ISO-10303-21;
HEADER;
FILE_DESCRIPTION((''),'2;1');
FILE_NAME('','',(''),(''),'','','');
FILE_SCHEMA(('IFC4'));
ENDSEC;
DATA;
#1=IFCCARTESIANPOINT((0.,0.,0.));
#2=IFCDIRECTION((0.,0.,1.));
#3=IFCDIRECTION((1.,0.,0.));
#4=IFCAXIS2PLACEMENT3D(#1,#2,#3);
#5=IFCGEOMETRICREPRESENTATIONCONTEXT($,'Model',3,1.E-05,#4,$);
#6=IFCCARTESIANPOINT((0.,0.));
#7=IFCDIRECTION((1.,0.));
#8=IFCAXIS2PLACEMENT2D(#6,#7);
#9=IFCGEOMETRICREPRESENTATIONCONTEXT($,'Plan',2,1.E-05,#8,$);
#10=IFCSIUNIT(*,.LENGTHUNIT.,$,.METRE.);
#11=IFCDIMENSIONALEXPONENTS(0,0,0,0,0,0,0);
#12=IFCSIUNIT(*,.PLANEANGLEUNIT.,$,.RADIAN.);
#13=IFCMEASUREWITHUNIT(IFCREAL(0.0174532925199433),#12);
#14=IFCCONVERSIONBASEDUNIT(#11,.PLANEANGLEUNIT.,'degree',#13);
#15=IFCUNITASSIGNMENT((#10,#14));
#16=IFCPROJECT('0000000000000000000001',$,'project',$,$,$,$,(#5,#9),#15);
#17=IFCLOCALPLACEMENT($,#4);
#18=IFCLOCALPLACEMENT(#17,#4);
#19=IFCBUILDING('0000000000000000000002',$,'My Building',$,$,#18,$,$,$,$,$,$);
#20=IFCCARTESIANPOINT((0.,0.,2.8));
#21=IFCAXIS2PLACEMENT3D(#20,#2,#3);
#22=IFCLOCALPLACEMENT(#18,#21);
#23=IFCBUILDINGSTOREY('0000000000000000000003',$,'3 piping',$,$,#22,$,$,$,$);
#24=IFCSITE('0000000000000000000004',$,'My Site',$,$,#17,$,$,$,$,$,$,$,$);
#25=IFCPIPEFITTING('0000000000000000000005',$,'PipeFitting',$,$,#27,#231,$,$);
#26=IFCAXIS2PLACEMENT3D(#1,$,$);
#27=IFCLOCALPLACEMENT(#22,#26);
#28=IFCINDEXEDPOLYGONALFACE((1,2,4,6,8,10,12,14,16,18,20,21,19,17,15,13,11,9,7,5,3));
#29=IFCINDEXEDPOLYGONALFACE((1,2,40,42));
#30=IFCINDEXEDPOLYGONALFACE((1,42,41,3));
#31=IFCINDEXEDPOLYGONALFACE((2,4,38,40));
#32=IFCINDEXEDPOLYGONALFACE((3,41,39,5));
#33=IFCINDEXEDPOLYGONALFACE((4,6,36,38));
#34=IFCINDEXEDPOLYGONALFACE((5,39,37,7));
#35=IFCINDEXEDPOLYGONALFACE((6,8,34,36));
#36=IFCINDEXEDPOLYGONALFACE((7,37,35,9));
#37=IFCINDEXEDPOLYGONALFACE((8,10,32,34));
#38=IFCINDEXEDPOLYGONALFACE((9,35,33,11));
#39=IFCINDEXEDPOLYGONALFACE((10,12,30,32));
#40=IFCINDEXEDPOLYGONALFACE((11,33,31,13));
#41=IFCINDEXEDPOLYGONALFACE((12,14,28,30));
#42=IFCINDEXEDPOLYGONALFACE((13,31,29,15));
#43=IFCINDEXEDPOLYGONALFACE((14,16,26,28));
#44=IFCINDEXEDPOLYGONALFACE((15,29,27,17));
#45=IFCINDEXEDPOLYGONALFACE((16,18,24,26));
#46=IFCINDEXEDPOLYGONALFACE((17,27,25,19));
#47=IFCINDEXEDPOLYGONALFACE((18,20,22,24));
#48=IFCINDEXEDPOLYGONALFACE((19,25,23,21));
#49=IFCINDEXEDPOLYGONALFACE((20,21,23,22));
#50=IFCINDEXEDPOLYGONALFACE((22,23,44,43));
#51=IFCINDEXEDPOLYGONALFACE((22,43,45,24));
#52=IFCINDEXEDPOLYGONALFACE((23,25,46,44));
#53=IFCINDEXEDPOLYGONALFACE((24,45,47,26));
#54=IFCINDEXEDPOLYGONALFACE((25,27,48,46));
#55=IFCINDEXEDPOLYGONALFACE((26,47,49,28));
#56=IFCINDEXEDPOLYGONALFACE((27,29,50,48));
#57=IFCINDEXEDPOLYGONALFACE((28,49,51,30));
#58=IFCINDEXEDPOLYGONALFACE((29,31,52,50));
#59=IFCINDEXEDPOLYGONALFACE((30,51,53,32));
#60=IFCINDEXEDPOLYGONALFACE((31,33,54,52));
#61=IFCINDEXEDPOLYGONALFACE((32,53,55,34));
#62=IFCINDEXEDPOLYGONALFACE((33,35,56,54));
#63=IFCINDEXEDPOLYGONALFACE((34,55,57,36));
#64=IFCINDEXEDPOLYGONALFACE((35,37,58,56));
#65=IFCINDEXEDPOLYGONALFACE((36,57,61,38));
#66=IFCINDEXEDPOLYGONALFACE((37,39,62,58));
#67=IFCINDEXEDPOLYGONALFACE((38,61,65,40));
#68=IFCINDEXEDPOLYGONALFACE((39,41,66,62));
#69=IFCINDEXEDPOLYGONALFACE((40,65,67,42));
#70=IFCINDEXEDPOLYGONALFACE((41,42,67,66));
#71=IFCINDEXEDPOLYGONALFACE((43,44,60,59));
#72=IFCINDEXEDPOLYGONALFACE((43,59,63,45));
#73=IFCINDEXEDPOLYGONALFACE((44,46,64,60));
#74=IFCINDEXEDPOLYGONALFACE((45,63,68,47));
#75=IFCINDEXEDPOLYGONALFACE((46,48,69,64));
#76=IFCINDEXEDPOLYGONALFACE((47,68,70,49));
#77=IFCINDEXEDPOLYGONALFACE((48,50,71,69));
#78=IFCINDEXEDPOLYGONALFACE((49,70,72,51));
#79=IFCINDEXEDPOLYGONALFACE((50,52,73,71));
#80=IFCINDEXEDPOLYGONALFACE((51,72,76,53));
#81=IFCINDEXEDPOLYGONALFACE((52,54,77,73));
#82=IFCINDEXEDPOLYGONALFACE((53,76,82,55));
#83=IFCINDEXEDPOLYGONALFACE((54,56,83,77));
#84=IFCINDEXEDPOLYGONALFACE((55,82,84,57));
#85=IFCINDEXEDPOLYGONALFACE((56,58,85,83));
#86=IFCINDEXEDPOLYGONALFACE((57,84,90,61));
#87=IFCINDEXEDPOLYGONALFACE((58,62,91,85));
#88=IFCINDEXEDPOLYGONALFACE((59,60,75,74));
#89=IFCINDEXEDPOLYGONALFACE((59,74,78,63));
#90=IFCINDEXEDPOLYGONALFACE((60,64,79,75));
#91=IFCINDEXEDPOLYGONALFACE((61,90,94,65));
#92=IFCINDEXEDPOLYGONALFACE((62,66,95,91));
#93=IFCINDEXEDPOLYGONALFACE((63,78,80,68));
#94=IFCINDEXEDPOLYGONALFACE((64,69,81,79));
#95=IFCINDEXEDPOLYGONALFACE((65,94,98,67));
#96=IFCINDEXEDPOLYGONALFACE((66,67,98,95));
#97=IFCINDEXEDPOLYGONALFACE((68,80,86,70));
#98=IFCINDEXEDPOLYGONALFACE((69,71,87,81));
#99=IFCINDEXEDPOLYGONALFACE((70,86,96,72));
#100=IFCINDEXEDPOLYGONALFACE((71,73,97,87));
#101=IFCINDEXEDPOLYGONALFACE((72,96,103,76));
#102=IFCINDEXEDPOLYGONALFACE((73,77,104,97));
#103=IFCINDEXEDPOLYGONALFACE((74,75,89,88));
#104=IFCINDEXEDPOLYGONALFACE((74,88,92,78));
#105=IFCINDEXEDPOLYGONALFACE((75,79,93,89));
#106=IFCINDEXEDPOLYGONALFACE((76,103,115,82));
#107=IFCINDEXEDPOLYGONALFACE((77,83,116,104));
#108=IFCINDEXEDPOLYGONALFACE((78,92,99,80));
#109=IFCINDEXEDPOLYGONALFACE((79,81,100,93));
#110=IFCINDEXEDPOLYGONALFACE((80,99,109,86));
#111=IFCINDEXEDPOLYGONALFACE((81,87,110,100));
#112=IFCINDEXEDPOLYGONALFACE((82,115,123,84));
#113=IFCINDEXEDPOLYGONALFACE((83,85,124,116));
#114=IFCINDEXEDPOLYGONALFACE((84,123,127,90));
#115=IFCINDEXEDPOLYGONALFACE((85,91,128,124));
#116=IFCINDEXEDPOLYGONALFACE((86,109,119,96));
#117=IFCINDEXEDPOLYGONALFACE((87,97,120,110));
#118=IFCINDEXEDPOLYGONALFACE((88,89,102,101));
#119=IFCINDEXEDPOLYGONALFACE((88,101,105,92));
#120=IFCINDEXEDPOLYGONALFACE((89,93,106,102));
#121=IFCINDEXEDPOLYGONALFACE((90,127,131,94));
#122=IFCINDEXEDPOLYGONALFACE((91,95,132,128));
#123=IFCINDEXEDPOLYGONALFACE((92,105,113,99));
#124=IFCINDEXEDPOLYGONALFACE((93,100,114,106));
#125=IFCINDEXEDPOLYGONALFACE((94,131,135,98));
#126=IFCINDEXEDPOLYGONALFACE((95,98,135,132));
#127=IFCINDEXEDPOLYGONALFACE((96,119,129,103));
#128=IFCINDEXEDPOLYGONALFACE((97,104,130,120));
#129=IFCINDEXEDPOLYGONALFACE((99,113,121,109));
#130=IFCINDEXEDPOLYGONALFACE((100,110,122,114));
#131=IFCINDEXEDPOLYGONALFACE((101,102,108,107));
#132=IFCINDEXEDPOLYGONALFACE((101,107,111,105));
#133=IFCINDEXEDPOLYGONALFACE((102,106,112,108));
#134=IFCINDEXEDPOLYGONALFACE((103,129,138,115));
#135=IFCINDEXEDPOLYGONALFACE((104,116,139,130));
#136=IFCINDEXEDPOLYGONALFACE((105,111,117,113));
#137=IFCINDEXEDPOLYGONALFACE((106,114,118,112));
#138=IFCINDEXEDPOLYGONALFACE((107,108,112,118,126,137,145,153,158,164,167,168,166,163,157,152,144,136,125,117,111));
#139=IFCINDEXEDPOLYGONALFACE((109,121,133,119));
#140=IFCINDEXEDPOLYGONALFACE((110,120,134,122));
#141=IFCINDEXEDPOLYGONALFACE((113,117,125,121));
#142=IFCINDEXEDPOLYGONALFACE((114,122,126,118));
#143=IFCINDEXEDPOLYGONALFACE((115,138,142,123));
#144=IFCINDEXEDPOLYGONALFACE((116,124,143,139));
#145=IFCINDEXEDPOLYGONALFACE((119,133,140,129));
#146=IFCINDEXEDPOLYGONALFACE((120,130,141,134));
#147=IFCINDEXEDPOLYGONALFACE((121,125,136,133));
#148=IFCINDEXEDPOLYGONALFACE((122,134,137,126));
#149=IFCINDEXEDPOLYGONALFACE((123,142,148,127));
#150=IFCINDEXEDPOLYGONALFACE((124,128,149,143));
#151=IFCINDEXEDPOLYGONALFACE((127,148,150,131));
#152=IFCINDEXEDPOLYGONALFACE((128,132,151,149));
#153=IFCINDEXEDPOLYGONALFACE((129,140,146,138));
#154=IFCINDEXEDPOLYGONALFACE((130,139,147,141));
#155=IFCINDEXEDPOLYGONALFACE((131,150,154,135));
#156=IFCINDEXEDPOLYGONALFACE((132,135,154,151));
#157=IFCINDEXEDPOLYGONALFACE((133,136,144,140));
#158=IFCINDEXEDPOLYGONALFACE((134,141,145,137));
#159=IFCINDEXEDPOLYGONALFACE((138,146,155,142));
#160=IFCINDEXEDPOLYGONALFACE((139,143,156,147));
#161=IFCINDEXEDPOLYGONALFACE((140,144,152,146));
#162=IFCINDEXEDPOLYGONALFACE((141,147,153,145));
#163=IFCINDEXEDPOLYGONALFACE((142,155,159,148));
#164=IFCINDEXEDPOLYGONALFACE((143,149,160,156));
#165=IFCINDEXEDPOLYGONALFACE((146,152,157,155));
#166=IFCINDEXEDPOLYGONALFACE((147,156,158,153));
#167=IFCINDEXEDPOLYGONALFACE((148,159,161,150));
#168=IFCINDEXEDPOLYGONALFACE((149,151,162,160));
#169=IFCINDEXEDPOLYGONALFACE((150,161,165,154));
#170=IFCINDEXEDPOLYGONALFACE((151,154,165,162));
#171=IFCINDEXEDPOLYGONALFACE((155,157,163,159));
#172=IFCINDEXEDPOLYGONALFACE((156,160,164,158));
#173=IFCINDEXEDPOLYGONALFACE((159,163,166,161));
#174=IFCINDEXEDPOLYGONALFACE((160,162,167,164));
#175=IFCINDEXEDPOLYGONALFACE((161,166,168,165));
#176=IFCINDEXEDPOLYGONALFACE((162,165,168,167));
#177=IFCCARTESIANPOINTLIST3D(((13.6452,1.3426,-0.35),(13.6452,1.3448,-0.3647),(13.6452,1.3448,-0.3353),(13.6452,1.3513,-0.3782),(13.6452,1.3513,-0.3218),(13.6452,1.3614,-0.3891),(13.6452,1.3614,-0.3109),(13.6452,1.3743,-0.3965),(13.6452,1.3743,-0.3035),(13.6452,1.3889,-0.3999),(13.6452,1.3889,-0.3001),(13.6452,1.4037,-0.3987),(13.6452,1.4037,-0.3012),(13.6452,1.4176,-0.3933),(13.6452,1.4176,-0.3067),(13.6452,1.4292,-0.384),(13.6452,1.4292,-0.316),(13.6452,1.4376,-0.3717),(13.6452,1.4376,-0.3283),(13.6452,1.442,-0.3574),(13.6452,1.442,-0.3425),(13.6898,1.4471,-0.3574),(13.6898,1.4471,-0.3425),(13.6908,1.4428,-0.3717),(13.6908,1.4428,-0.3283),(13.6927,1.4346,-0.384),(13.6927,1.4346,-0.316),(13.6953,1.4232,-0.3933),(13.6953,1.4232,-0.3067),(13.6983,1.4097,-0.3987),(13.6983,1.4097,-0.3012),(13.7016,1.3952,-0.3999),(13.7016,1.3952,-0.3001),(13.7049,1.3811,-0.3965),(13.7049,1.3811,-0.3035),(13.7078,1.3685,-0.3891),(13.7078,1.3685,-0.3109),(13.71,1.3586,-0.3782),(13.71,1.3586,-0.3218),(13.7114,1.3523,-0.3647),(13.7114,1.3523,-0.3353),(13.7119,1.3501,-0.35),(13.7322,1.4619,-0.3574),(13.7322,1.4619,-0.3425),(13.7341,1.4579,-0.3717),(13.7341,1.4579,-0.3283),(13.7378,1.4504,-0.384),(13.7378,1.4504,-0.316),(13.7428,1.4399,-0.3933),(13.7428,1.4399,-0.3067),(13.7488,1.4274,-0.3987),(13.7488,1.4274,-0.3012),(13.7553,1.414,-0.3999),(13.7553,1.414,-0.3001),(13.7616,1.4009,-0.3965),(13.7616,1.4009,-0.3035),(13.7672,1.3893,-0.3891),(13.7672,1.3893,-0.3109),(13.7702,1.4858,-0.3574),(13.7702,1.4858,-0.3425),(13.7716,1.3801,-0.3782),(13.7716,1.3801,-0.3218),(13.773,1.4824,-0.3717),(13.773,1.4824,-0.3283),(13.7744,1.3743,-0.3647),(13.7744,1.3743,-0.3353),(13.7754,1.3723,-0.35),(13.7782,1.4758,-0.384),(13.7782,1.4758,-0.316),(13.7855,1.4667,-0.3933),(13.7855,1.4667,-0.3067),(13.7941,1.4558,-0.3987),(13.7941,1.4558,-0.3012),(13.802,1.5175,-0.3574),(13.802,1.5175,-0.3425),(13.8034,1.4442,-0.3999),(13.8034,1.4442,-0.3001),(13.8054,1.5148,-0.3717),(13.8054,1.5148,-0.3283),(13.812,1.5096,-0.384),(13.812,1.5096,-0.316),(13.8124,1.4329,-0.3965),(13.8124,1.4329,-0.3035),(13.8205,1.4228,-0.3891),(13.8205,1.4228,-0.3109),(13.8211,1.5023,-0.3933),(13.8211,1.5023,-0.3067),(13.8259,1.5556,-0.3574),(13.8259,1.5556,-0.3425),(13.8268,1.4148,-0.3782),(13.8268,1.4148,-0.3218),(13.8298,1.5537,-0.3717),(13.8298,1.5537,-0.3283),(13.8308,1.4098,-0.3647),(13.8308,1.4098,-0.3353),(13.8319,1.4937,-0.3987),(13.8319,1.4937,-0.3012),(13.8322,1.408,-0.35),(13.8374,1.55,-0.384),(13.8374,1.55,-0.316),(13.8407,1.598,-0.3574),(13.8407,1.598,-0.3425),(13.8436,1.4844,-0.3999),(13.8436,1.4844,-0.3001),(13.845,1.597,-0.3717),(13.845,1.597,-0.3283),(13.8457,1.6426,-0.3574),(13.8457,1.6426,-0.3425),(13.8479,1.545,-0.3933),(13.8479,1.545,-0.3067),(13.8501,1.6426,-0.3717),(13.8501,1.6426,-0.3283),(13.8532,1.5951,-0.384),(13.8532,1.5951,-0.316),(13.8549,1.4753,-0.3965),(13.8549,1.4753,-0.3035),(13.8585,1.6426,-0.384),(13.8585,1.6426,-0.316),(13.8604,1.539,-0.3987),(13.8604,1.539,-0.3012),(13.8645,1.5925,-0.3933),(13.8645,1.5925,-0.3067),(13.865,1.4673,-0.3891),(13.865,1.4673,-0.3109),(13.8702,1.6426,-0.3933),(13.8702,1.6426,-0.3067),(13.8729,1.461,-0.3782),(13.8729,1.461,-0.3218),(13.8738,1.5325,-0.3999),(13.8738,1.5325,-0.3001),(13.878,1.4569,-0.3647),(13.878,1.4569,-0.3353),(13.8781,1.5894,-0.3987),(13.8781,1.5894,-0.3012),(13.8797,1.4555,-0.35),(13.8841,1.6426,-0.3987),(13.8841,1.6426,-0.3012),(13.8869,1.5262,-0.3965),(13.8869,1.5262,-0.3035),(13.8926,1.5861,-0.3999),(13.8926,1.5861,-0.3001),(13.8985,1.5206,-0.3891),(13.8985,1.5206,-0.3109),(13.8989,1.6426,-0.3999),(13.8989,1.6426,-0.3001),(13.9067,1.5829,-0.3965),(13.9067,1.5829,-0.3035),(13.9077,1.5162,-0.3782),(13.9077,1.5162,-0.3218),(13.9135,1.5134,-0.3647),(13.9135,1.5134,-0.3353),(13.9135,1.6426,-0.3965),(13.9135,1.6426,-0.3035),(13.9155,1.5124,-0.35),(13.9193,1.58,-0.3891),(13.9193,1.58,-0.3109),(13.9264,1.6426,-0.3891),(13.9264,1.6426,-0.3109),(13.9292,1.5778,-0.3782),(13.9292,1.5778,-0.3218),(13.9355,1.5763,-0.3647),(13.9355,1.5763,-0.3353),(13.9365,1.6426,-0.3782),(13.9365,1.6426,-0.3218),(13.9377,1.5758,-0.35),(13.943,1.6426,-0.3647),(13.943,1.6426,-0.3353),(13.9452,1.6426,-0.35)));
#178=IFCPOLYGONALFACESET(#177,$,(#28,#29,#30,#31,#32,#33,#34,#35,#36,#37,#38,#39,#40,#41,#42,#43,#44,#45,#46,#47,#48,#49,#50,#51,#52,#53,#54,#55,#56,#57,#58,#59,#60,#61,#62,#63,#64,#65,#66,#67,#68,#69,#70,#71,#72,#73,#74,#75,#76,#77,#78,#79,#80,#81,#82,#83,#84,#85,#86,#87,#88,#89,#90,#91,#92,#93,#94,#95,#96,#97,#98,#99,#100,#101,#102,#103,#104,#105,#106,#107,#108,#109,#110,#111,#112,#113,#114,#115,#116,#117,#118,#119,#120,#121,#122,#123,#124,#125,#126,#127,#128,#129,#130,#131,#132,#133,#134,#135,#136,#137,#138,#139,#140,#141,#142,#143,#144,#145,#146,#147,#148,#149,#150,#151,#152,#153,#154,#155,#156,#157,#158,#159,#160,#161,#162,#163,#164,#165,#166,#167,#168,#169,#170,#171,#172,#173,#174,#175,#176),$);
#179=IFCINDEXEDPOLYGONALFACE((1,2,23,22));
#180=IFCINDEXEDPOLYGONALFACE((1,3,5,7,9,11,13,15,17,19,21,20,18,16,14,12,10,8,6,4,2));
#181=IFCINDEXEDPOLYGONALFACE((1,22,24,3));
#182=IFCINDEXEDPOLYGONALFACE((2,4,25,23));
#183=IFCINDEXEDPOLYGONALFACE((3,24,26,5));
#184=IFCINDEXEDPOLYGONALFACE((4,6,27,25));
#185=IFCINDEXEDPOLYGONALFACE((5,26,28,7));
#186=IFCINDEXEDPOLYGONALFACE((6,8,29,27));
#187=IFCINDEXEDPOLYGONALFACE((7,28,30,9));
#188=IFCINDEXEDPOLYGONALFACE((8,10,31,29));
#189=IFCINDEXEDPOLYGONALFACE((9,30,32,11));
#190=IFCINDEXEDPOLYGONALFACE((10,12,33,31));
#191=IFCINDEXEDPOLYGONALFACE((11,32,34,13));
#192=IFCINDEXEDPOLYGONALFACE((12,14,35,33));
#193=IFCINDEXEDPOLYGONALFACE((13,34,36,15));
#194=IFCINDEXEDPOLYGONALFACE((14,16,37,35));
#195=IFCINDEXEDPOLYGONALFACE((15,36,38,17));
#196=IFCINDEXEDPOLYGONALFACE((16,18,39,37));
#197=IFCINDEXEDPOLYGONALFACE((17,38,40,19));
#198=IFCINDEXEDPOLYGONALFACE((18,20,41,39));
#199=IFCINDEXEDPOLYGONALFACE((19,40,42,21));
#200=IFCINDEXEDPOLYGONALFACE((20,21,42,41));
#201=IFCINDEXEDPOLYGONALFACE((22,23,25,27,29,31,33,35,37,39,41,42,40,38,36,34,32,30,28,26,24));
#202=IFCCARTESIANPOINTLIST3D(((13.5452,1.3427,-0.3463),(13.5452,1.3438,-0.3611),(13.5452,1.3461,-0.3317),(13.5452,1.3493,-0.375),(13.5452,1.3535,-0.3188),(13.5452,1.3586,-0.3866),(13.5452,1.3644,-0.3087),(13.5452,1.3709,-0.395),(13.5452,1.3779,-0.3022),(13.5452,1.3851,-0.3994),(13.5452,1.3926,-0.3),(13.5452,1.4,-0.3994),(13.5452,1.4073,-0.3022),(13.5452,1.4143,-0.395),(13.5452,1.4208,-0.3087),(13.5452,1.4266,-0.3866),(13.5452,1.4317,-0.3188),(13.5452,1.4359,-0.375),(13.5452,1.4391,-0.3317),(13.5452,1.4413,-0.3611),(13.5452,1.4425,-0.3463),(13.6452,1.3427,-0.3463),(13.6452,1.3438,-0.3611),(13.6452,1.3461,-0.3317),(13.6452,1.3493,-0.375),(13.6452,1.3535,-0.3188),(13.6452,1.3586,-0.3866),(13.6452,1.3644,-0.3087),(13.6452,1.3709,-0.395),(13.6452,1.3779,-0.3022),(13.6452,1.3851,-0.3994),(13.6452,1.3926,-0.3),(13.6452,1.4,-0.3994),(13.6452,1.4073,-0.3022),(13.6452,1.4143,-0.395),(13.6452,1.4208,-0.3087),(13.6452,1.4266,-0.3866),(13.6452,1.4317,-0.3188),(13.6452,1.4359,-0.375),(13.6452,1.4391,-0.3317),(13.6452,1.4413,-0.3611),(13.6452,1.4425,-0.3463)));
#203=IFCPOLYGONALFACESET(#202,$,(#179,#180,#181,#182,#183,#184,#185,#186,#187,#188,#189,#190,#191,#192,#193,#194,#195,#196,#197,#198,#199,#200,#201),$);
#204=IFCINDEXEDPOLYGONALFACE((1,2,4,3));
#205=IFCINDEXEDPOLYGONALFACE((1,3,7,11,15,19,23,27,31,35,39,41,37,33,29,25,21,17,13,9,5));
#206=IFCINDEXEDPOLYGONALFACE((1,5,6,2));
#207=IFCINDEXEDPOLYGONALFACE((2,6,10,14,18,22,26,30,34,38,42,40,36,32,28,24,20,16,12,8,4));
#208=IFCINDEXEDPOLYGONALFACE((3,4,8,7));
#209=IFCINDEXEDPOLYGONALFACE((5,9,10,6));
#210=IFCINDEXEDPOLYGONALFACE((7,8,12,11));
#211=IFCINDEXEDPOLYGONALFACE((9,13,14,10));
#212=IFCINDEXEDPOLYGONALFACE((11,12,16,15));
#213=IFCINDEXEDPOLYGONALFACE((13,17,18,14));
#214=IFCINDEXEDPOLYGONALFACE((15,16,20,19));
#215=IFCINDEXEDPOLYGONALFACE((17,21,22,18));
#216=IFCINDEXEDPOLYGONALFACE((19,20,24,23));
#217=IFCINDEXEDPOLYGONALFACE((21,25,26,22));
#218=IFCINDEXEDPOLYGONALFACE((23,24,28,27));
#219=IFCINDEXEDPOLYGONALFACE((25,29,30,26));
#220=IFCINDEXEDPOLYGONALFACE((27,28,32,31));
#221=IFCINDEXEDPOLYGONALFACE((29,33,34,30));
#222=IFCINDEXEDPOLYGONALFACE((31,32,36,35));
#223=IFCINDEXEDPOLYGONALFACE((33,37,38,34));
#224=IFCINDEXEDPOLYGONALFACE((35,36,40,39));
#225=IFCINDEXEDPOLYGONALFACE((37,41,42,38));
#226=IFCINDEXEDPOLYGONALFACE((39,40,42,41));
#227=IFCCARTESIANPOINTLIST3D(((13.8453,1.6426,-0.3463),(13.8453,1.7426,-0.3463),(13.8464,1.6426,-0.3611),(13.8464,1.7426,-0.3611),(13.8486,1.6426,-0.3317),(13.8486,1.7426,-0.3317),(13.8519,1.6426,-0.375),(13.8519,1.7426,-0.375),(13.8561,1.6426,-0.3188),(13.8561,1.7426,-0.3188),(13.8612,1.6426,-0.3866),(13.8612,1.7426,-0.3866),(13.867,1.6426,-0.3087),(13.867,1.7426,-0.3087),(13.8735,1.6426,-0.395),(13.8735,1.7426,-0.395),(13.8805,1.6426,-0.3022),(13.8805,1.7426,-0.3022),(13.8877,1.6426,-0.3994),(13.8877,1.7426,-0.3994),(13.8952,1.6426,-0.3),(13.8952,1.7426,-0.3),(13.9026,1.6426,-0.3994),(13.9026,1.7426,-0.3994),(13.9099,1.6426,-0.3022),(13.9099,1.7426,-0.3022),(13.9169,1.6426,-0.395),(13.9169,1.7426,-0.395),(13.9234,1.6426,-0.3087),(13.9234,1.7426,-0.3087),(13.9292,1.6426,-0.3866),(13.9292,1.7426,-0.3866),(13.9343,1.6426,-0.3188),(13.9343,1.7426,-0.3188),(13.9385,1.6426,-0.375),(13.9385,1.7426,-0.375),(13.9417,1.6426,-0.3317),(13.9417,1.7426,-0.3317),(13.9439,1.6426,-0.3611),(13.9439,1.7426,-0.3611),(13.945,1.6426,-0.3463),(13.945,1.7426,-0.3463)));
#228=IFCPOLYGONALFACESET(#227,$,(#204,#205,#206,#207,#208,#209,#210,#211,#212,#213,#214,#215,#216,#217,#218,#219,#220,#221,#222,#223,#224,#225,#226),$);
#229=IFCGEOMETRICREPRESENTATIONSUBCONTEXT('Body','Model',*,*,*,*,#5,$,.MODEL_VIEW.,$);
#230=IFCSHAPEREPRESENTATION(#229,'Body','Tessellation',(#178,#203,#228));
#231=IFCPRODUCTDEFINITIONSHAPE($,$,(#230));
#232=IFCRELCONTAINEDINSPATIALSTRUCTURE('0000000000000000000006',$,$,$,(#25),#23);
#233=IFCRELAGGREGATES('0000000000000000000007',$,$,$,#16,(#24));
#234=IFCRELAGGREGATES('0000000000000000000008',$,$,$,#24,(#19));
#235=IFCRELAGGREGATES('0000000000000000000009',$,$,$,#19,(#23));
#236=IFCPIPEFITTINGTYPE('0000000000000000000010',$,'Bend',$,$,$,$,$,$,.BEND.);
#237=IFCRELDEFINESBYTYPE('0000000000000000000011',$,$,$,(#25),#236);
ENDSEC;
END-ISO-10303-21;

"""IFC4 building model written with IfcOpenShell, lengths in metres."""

from ifc_helpers import new_model, entity, si_unit, converted_unit, frame, origin_with_axes, origin_2d_with_axis, place, context, subcontext, project, spatial, circle, extrude, source, transform, mapped, type_object, type_shapes, element, save


model = new_model("IFC4")

# Units and contexts
model_context = context("Model", 3, precision=1e-05, world=origin_with_axes())
plan_context = context("Plan", 2, precision=1e-05, world=origin_2d_with_axis())
body_context = subcontext(model_context, "Body", "Model", "MODEL_VIEW")
ifc_project = project(units=[si_unit("LENGTHUNIT", "METRE"), converted_unit("PLANEANGLEUNIT", "degree", entity("IfcReal", 0.0174532925199433), si_unit("PLANEANGLEUNIT", "RADIAN"), dimensions=[0, 0, 0, 0, 0, 0, 0])], contexts=[model_context, plan_context])

# Site, building, storey
site_placement = place(None, origin_with_axes())
site = spatial("IfcSite", under=ifc_project, at=site_placement, Name="My Site")
building_placement = place(site_placement, origin_with_axes())
building = spatial("IfcBuilding", under=site, at=building_placement, Name="My Building")
storey_placement = place(building_placement, frame((0.0, 0.0, 2.8), z_axis=(0.0, 0.0, 1.0), x_axis=(1.0, 0.0, 0.0)))
storey = spatial("IfcBuildingStorey", under=building, at=storey_placement, Name="3 piping")

# Pipe fitting
pipe_fitting_type_1 = type_object("IfcPipeFittingType", Name="Bend", PredefinedType="BEND")
shared_shape = source(origin_with_axes(), body_context, "Body", "SolidModel", [
    entity("IfcSweptDiskSolid", entity("IfcIndexedPolyCurve", entity("IfcCartesianPointList3D", [[0.0, 0.0, 0.1], [0.0, -0.0732, 0.2768], [0.0, -0.25, 0.35]]), [entity("IfcArcIndex", [1, 2, 3])]), 0.05),
    extrude(circle(Radius=0.05), origin_with_axes(), (0.0, 0.0, 1.0), 0.1),
    extrude(circle(Radius=0.05), frame((0.0, -0.25, 0.35), z_axis=(0.0, -1.0, 0.0), x_axis=(1.0, 0.0, 0.0)), (0.0, 0.0, 1.0), 0.1),
])
type_shapes(pipe_fitting_type_1, [shared_shape])
for number, where, z_axis, x_axis, name in (
    (1, (13.5452, 1.3926, -0.35), (1.0, 0.0, 0.0), (0.0, 0.0, 1.0), "PipeFitting"),
):
    element("IfcPipeFitting", number, at=place(storey_placement, frame(where, z_axis=z_axis, x_axis=x_axis)), inside=storey, type_object=pipe_fitting_type_1, Name=name, context=body_context, shape_type="MappedRepresentation", body=[
        mapped(shared_shape, transform((0.0, 0.0, 0.0), x_axis=(1.0, 0.0, 0.0), y_axis=(0.0, 1.0, 0.0), z_axis=(0.0, 0.0, 1.0), scale=1.0)),
    ])

save(model, "model.ifc")
